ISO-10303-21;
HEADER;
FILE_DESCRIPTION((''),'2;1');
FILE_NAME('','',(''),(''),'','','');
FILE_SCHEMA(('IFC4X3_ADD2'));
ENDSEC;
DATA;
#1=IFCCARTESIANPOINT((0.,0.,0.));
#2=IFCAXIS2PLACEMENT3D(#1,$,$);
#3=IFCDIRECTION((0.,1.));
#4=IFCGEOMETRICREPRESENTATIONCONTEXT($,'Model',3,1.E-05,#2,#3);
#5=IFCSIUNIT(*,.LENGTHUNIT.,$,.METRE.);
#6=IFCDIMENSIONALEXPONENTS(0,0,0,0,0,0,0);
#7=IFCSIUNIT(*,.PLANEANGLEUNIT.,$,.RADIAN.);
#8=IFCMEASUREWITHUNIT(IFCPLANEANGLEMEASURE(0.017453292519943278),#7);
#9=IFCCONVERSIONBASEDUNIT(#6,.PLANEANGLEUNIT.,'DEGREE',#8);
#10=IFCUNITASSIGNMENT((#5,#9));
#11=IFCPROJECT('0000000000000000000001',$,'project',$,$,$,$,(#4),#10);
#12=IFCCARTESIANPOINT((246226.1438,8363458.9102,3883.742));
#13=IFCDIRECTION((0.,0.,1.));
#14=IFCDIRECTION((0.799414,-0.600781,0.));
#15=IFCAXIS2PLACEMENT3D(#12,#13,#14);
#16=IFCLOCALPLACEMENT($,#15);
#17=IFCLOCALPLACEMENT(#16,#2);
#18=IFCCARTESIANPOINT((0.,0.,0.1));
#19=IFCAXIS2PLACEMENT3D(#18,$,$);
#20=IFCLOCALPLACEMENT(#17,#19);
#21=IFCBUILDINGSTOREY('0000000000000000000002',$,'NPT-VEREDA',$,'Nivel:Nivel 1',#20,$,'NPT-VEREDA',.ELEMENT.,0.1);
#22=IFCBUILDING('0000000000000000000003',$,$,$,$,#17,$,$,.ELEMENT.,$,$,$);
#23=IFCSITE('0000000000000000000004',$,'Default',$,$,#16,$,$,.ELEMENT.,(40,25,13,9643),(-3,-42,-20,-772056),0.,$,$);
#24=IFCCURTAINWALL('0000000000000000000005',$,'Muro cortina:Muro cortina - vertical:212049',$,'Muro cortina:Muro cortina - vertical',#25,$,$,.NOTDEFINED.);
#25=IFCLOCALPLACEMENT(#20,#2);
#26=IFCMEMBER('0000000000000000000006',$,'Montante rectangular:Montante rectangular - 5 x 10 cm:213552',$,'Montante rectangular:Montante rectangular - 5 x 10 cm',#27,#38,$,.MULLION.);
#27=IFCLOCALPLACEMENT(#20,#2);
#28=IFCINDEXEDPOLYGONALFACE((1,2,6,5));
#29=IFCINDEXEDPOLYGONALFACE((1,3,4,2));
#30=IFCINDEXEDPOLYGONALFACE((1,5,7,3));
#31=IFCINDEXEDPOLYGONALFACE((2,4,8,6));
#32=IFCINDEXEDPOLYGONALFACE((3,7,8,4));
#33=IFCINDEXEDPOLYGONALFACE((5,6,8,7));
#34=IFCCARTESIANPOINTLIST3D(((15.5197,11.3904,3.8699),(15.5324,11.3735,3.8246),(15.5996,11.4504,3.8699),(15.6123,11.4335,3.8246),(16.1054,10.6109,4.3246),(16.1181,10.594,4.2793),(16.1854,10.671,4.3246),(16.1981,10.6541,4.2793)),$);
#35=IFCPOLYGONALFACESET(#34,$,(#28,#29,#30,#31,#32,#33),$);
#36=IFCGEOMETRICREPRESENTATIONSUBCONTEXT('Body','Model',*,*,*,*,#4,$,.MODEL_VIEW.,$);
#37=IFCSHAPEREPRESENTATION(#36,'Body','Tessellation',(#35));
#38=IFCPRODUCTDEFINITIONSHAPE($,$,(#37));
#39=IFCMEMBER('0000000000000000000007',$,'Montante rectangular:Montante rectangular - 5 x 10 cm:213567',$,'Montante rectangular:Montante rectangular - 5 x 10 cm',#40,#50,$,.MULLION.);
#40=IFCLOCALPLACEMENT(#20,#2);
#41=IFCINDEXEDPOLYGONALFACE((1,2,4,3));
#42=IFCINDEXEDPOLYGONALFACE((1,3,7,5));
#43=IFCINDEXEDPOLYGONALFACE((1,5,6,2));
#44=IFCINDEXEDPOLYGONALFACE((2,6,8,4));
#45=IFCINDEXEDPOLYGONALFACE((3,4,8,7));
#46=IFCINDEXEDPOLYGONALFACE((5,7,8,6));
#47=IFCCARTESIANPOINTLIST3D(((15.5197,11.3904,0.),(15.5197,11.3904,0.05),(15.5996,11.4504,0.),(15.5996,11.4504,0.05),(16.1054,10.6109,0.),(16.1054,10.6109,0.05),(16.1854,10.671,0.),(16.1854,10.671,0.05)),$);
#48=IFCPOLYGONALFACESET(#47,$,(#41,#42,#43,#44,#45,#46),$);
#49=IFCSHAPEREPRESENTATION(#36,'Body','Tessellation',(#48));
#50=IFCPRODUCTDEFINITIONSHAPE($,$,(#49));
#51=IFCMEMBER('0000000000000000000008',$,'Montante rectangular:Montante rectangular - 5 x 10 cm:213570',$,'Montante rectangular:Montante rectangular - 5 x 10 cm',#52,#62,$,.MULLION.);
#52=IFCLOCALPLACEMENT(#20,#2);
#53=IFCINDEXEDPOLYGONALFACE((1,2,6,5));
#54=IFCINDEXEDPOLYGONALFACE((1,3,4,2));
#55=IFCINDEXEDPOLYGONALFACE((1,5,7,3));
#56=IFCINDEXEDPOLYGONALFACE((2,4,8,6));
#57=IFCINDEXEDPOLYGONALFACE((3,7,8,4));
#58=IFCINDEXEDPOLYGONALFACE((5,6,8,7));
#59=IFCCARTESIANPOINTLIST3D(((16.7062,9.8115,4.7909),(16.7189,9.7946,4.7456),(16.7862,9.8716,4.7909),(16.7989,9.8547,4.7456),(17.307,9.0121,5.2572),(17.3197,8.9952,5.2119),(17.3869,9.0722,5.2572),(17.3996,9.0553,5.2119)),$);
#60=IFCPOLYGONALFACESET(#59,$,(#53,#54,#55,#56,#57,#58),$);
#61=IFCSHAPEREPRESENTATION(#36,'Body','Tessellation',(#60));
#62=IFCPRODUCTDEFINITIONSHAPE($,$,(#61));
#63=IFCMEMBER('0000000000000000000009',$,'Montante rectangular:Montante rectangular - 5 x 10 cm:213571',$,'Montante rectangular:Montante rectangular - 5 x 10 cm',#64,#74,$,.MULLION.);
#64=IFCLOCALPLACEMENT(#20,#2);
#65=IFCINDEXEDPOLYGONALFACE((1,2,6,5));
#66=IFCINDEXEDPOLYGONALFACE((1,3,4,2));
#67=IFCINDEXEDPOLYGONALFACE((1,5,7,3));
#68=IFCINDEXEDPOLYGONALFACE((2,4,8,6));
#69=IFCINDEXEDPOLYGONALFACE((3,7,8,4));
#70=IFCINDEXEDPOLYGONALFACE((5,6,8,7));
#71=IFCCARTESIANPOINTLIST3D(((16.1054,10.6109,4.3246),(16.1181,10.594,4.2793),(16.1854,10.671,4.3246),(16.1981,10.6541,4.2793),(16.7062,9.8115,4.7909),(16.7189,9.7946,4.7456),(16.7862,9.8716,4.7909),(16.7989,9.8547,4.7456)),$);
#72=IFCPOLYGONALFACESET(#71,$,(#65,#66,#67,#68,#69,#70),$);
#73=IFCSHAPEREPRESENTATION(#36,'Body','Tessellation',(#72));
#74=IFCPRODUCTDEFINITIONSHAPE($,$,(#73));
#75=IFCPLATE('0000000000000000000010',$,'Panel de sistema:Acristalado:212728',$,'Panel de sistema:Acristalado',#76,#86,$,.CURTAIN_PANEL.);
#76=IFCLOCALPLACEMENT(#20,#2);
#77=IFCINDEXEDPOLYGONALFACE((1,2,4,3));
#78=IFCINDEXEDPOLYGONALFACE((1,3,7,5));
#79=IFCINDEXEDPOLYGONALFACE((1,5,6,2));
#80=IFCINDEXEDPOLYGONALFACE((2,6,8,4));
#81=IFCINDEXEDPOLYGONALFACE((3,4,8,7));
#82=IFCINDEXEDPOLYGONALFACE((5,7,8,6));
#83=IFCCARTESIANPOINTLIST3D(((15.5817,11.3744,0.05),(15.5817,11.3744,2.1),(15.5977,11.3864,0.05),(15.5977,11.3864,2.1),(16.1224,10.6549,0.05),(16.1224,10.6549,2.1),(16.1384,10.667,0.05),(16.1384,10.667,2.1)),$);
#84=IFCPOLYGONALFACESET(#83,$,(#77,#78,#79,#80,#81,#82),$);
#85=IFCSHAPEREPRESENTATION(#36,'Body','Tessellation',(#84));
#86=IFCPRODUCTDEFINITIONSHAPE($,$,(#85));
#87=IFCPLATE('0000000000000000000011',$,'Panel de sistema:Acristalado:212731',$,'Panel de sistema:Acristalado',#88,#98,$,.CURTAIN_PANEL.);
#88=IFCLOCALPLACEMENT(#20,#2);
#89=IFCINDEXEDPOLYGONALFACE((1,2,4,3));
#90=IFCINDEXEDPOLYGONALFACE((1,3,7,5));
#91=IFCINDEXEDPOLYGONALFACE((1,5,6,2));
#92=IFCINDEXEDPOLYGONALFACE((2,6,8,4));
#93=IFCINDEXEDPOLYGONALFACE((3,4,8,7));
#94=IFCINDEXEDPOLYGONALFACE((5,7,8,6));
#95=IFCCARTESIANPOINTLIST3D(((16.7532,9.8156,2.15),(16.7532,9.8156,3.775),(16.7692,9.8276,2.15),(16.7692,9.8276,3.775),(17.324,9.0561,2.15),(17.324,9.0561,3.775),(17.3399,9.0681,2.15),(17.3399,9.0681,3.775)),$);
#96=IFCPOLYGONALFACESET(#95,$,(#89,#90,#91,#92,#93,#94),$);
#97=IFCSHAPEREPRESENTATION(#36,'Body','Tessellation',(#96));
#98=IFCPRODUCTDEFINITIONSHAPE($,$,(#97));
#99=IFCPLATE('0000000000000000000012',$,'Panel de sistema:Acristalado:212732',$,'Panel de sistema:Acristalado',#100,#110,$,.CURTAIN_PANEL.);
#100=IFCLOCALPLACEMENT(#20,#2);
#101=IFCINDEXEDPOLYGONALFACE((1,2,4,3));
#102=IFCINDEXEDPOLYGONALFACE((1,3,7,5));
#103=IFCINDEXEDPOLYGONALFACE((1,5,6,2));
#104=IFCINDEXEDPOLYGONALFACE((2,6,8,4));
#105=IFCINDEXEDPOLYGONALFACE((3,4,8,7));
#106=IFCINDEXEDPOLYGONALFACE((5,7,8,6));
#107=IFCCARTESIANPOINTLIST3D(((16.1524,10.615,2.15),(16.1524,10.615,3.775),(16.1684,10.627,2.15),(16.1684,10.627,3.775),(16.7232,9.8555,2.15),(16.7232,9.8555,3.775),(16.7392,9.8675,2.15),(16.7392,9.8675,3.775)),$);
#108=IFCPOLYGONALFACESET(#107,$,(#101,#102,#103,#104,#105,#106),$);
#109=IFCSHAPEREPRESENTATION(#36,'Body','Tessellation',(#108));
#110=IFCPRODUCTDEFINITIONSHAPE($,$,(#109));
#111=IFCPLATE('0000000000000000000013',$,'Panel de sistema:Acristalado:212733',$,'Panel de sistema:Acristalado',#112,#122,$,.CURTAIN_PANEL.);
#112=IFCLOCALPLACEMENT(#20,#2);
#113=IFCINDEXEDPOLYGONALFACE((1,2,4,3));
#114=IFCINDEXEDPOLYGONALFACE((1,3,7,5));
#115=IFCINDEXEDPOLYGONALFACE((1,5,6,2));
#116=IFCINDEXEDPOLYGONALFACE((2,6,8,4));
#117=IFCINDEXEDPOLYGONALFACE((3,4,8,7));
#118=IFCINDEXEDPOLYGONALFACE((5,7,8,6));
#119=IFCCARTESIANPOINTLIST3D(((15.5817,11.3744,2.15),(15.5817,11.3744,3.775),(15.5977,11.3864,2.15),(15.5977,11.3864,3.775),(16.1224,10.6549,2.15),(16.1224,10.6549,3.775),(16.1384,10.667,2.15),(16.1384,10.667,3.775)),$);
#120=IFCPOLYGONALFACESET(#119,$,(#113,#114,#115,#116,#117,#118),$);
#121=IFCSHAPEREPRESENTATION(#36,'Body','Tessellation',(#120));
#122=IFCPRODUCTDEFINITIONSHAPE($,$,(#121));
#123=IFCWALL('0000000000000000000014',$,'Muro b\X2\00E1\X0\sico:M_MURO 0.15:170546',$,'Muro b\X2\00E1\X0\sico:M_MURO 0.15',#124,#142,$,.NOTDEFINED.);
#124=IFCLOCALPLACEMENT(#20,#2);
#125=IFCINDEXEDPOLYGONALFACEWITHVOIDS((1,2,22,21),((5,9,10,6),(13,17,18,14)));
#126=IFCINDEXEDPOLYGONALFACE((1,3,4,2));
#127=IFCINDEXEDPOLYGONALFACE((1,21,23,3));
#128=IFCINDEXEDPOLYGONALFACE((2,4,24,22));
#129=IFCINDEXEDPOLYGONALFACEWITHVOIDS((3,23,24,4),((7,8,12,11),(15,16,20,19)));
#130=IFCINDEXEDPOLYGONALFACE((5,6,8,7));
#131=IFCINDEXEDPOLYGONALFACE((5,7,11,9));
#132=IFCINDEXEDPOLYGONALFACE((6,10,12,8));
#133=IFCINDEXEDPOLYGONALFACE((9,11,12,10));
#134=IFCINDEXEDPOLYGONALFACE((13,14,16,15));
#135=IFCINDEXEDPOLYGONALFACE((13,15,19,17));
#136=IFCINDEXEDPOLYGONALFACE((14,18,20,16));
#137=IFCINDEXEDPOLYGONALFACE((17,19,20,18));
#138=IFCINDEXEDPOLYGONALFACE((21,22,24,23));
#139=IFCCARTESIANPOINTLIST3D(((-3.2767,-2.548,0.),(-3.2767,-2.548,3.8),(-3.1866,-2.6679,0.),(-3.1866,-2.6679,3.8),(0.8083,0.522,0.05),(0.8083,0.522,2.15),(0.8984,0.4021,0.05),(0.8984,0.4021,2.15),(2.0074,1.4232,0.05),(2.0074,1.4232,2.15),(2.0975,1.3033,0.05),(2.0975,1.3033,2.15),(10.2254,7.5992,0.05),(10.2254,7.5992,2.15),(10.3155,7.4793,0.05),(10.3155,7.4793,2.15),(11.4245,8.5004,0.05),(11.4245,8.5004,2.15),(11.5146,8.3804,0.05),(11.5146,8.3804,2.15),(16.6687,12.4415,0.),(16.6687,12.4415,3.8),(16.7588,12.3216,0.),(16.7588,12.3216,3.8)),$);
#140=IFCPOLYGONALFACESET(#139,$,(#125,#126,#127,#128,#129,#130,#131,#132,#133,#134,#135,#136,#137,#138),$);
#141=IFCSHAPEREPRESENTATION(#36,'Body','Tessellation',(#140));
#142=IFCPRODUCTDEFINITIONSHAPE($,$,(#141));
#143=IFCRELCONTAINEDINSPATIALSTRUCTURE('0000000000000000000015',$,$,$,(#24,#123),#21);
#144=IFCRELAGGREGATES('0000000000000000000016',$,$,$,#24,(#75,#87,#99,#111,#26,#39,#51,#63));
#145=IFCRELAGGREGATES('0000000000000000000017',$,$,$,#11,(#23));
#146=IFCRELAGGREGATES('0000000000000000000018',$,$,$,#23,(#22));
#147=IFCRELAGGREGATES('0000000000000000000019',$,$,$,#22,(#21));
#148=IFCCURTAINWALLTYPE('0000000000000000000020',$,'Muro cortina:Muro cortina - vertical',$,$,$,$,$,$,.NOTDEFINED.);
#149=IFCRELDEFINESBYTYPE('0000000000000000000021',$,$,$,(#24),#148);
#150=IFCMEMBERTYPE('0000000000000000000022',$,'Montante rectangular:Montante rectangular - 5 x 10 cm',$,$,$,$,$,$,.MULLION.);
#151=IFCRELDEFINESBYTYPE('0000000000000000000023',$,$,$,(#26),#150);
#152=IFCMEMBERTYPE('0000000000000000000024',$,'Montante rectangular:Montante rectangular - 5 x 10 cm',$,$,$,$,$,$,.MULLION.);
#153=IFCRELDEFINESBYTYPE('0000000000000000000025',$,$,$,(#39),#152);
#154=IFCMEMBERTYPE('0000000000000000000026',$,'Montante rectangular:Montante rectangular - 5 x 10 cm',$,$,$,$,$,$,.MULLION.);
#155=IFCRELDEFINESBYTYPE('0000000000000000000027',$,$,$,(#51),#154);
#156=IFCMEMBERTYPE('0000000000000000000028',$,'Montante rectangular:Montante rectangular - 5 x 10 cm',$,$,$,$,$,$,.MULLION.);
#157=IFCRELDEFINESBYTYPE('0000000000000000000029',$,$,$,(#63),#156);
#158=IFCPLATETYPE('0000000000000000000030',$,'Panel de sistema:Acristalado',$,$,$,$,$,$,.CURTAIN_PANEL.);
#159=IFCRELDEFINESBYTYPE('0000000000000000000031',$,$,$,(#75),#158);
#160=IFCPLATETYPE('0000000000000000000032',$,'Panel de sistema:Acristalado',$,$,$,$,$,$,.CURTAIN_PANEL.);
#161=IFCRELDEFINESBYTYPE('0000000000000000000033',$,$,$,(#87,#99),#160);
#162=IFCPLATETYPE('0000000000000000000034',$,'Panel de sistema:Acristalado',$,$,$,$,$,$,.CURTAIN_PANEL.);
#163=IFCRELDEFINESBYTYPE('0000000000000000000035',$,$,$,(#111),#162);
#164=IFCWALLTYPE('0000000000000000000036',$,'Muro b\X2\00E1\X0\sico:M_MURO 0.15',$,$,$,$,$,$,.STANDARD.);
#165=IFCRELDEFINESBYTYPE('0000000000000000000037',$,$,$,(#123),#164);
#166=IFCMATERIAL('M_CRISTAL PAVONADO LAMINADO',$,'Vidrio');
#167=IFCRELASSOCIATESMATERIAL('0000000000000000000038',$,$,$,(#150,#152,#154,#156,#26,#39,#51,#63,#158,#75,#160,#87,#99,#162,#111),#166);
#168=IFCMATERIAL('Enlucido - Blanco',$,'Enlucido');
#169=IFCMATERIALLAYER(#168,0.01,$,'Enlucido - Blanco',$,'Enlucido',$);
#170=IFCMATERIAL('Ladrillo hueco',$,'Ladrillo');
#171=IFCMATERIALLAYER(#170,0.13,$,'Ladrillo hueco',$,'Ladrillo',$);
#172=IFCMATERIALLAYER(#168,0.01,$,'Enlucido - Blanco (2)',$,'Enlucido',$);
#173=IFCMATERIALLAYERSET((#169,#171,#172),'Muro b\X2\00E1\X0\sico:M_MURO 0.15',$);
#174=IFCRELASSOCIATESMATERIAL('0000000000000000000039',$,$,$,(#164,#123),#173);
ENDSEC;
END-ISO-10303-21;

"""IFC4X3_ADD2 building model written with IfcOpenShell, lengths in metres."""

from ifc_helpers import new_model, entity, si_unit, converted_unit, direction, frame, frame_2d, origin, origin_2d_with_axis, place, context, subcontext, project, spatial, polyline, rectangle, outline, extrude, source, transform, mapped, material, layer, layer_set, material_profile, profile_set, profile_usage, type_object, type_shapes, element, aggregate, save


model = new_model("IFC4X3_ADD2")

# Units and contexts
model_context = context("Model", 3, precision=1e-05, world=origin(), true_north=direction((0.0, 1.0)))
body_context = subcontext(model_context, "Body", "Model", "MODEL_VIEW")
ifc_project = project(units=[si_unit("LENGTHUNIT", "METRE"), converted_unit("PLANEANGLEUNIT", "DEGREE", entity("IfcPlaneAngleMeasure", 0.017453292519943278), si_unit("PLANEANGLEUNIT", "RADIAN"), dimensions=[0, 0, 0, 0, 0, 0, 0])], contexts=[model_context])

# Site, building, storey
site_placement = place(None, frame((246226.1438, 8363458.9102, 3883.742), z_axis=(0.0, 0.0, 1.0), x_axis=(0.799414, -0.600781, 0.0)))
site = spatial("IfcSite", under=ifc_project, at=site_placement, Name="Default", CompositionType="ELEMENT", RefLatitude=(40, 25, 13, 9643), RefLongitude=(-3, -42, -20, -772056), RefElevation=0.0)
building_placement = place(site_placement, origin())
building = spatial("IfcBuilding", under=site, at=building_placement, CompositionType="ELEMENT")
storey_placement = place(building_placement, frame((0.0, 0.0, 0.1)))
storey = spatial("IfcBuildingStorey", under=building, at=storey_placement, Name="NPT-VEREDA", ObjectType="Nivel:Nivel 1", LongName="NPT-VEREDA", CompositionType="ELEMENT", Elevation=0.1)

# Curtain wall, members, plates
curtain_wall_type = type_object("IfcCurtainWallType", Name="Muro cortina:Muro cortina - vertical", PredefinedType="NOTDEFINED")
curtain_wall_placement = place(storey_placement, frame((0.0, 0.0, -0.1)))
curtain_wall = element("IfcCurtainWall", 1, at=curtain_wall_placement, inside=storey, type_object=curtain_wall_type, Name="Muro cortina:Muro cortina - vertical:212049", ObjectType="Muro cortina:Muro cortina - vertical", PredefinedType="NOTDEFINED")
ifc_material_1 = material(Name="M_CRISTAL PAVONADO LAMINADO", Category="Vidrio")
ifc_material_profile = material_profile(ifc_material_1, outline(polyline([(-0.9872, -0.025), (0.948, -0.025), (0.948, 0.025), (-0.9087, 0.025), (-0.9872, -0.025)])), Name="Montante rectangular - 5 x 10 cm")
ifc_profile_set = profile_set([ifc_material_profile], Name="Montante rectangular - 5 x 10 cm")
ifc_profile_usage = profile_usage(ifc_profile_set)
member_type_1 = type_object("IfcMemberType", Name="Montante rectangular:Montante rectangular - 5 x 10 cm", PredefinedType="MULLION", material=ifc_profile_set)
shared_shape_1 = source(origin(), body_context, "Body", "SweptSolid", [
    extrude(rectangle(XDim=1.0758, YDim=0.1, at=frame_2d((0.0, 0.0), x_axis=(1.0, 0.0))), frame((-0.05, 0.0, -0.5379), z_axis=(1.0, 0.0, 0.0), x_axis=(0.0, 0.0, -1.0)), (0.0, 0.0, 1.0), 0.05),
])
type_shapes(member_type_1, [shared_shape_1])
member_1_placement = place(curtain_wall_placement, frame((15.5596, 11.4204, 3.9699), z_axis=(-0.544492, 0.724516, -0.422618), x_axis=(-0.253901, 0.337847, 0.906308)))
member_1 = element("IfcMember", 2, at=member_1_placement, type_object=member_type_1, material=ifc_profile_usage, Name="Montante rectangular:Montante rectangular - 5 x 10 cm:213552", ObjectType="Montante rectangular:Montante rectangular - 5 x 10 cm", PredefinedType="MULLION", context=body_context, shape_type="MappedRepresentation", body=[
    mapped(shared_shape_1, transform((0.0, 0.0, 0.0), scale=1.0)),
])
member_type_2 = type_object("IfcMemberType", Name="Montante rectangular:Montante rectangular - 5 x 10 cm", PredefinedType="MULLION", material=ifc_profile_set)
shared_shape_2 = source(origin(), body_context, "Body", "SweptSolid", [
    extrude(rectangle(XDim=0.05, YDim=0.1, at=frame_2d((0.0, 0.0), x_axis=(1.0, 0.0))), frame((-0.025, 0.0, -0.975)), (0.0, 0.0, 1.0), 0.975),
])
type_shapes(member_type_2, [shared_shape_2])
member_2_placement = place(curtain_wall_placement, frame((16.1454, 10.641, 0.1), z_axis=(0.60078, -0.799414, 0.0), x_axis=(0.0, 0.0, -1.0)))
member_2 = element("IfcMember", 3, at=member_2_placement, type_object=member_type_2, material=ifc_profile_usage, Name="Montante rectangular:Montante rectangular - 5 x 10 cm:213567", ObjectType="Montante rectangular:Montante rectangular - 5 x 10 cm", PredefinedType="MULLION", context=body_context, shape_type="MappedRepresentation", body=[
    mapped(shared_shape_2, transform((0.0, 0.0, 0.0), scale=1.0)),
])
member_type_3 = type_object("IfcMemberType", Name="Montante rectangular:Montante rectangular - 5 x 10 cm", PredefinedType="MULLION", material=ifc_profile_set)
shared_shape_3 = source(origin(), body_context, "Body", "SweptSolid", [
    extrude(rectangle(XDim=0.1, YDim=0.05, at=origin_2d_with_axis()), frame((-0.025, 0.0, -1.1034), z_axis=(0.0, 0.0, 1.0), x_axis=(0.0, 1.0, 0.0)), (0.0, 0.0, 1.0), 1.1034),
])
type_shapes(member_type_3, [shared_shape_3])
member_3_placement = place(curtain_wall_placement, frame((16.7462, 9.8415, 4.8909), z_axis=(-0.544492, 0.724516, -0.422618), x_axis=(-0.253901, 0.337847, 0.906308)))
member_3 = element("IfcMember", 4, at=member_3_placement, type_object=member_type_3, material=ifc_profile_usage, Name="Montante rectangular:Montante rectangular - 5 x 10 cm:213570", ObjectType="Montante rectangular:Montante rectangular - 5 x 10 cm", PredefinedType="MULLION", context=body_context, shape_type="MappedRepresentation", body=[
    mapped(shared_shape_3, transform((0.0, 0.0, 0.0), scale=1.0)),
])
member_type_4 = type_object("IfcMemberType", Name="Montante rectangular:Montante rectangular - 5 x 10 cm", PredefinedType="MULLION", material=ifc_profile_set)
shared_shape_4 = source(origin(), body_context, "Body", "SweptSolid", [
    extrude(rectangle(XDim=0.1, YDim=0.05, at=origin_2d_with_axis()), frame((-0.025, 0.0, -1.1034), z_axis=(0.0, 0.0, 1.0), x_axis=(0.0, 1.0, 0.0)), (0.0, 0.0, 1.0), 1.1034),
])
type_shapes(member_type_4, [shared_shape_4])
member_4_placement = place(curtain_wall_placement, frame((16.1454, 10.641, 4.4246), z_axis=(-0.544492, 0.724516, -0.422618), x_axis=(-0.253901, 0.337847, 0.906308)))
member_4 = element("IfcMember", 5, at=member_4_placement, type_object=member_type_4, material=ifc_profile_usage, Name="Montante rectangular:Montante rectangular - 5 x 10 cm:213571", ObjectType="Montante rectangular:Montante rectangular - 5 x 10 cm", PredefinedType="MULLION", context=body_context, shape_type="MappedRepresentation", body=[
    mapped(shared_shape_4, transform((0.0, 0.0, 0.0), scale=1.0)),
])
plate_type_1 = type_object("IfcPlateType", Name="Panel de sistema:Acristalado", PredefinedType="CURTAIN_PANEL", material=ifc_material_1)
shared_shape_5 = source(origin(), body_context, "Body", "SweptSolid", [
    extrude(rectangle(XDim=0.02, YDim=0.9, at=frame_2d((0.0, 0.0), x_axis=(1.0, 0.0))), frame((0.0, 0.0, 0.0), z_axis=(0.0, 0.0, 1.0), x_axis=(0.0, 1.0, 0.0)), (0.0, 0.0, 1.0), 2.05),
])
type_shapes(plate_type_1, [shared_shape_5])
plate_1_placement = place(curtain_wall_placement, frame((15.86, 11.0207, 0.15), z_axis=(0.0, 0.0, 1.0), x_axis=(-0.60078, 0.799414, 0.0)))
plate_1 = element("IfcPlate", 6, at=plate_1_placement, type_object=plate_type_1, material=ifc_material_1, Name="Panel de sistema:Acristalado:212728", ObjectType="Panel de sistema:Acristalado", PredefinedType="CURTAIN_PANEL", context=body_context, shape_type="MappedRepresentation", body=[
    mapped(shared_shape_5, transform((0.0, 0.0, 0.0), scale=1.0)),
])
plate_type_2 = type_object("IfcPlateType", Name="Panel de sistema:Acristalado", PredefinedType="CURTAIN_PANEL", material=ifc_material_1)
shared_shape_6 = source(origin(), body_context, "Body", "SweptSolid", [
    extrude(rectangle(XDim=0.02, YDim=0.95, at=frame_2d((0.0, 0.0), x_axis=(1.0, 0.0))), frame((0.0, 0.0, 0.0), z_axis=(0.0, 0.0, 1.0), x_axis=(0.0, 1.0, 0.0)), (0.0, 0.0, 1.0), 1.625),
])
type_shapes(plate_type_2, [shared_shape_6])
plate_2_placement = place(curtain_wall_placement, frame((17.0466, 9.4418, 2.25), z_axis=(0.0, 0.0, 1.0), x_axis=(-0.60078, 0.799414, 0.0)))
plate_2 = element("IfcPlate", 7, at=plate_2_placement, type_object=plate_type_2, material=ifc_material_1, Name="Panel de sistema:Acristalado:212731", ObjectType="Panel de sistema:Acristalado", PredefinedType="CURTAIN_PANEL", context=body_context, shape_type="MappedRepresentation", body=[
    mapped(shared_shape_6, transform((0.0, 0.0, 0.0), scale=1.0)),
])
plate_3_placement = place(curtain_wall_placement, frame((16.4458, 10.2413, 2.25), z_axis=(0.0, 0.0, 1.0), x_axis=(-0.60078, 0.799414, 0.0)))
plate_3 = element("IfcPlate", 8, at=plate_3_placement, type_object=plate_type_2, material=ifc_material_1, Name="Panel de sistema:Acristalado:212732", ObjectType="Panel de sistema:Acristalado", PredefinedType="CURTAIN_PANEL", context=body_context, shape_type="MappedRepresentation", body=[
    mapped(shared_shape_6, transform((0.0, 0.0, 0.0), scale=1.0)),
])
plate_type_3 = type_object("IfcPlateType", Name="Panel de sistema:Acristalado", PredefinedType="CURTAIN_PANEL", material=ifc_material_1)
shared_shape_7 = source(origin(), body_context, "Body", "SweptSolid", [
    extrude(rectangle(XDim=0.02, YDim=0.9, at=frame_2d((0.0, 0.0), x_axis=(1.0, 0.0))), frame((0.0, 0.0, 0.0), z_axis=(0.0, 0.0, 1.0), x_axis=(0.0, 1.0, 0.0)), (0.0, 0.0, 1.0), 1.625),
])
type_shapes(plate_type_3, [shared_shape_7])
plate_4_placement = place(curtain_wall_placement, frame((15.86, 11.0207, 2.25), z_axis=(0.0, 0.0, 1.0), x_axis=(-0.60078, 0.799414, 0.0)))
plate_4 = element("IfcPlate", 9, at=plate_4_placement, type_object=plate_type_3, material=ifc_material_1, Name="Panel de sistema:Acristalado:212733", ObjectType="Panel de sistema:Acristalado", PredefinedType="CURTAIN_PANEL", context=body_context, shape_type="MappedRepresentation", body=[
    mapped(shared_shape_7, transform((0.0, 0.0, 0.0), scale=1.0)),
])
aggregate(curtain_wall, [plate_1, plate_2, plate_3, plate_4, member_1, member_2, member_3, member_4])

# Wall, openings
ifc_material_2 = material(Name="Enlucido - Blanco", Category="Enlucido")
ifc_layer_1 = layer(ifc_material_2, 0.01, Name="Enlucido - Blanco", Category="Enlucido")
ifc_material_3 = material(Name="Ladrillo hueco", Category="Ladrillo")
ifc_layer_2 = layer(ifc_material_3, 0.13, Name="Ladrillo hueco", Category="Ladrillo")
ifc_layer_3 = layer(ifc_material_2, 0.01, Name="Enlucido - Blanco (2)", Category="Enlucido")
ifc_layer_set = layer_set([ifc_layer_1, ifc_layer_2, ifc_layer_3], Name="Muro básico:M_MURO 0.15")
wall_type = type_object("IfcWallType", Name="Muro básico:M_MURO 0.15", PredefinedType="STANDARD", material=ifc_layer_set)
wall_placement = place(storey_placement, frame((16.7137, 12.3815, 0.0), z_axis=(0.0, 0.0, 1.0), x_axis=(-0.799414, -0.60078, 0.0)))
wall = element("IfcWall", 10, at=wall_placement, inside=storey, type_object=wall_type, material=ifc_layer_set, Name="Muro básico:M_MURO 0.15:170546", ObjectType="Muro básico:M_MURO 0.15", PredefinedType="NOTDEFINED", context=body_context, shape_type="SweptSolid", body=[
    extrude(rectangle(XDim=24.95, YDim=0.15, at=frame_2d((12.475, 0.0), x_axis=(-1.0, 0.0))), origin(), (0.0, 0.0, 1.0), 3.8),
])
opening_1_placement = place(wall_placement, frame((18.34, -0.075, 0.05)))
element("IfcOpeningElement", 11, at=opening_1_placement, cuts=wall, PredefinedType="OPENING", context=body_context, shape_type="SweptSolid", body=[
    extrude(rectangle(XDim=2.1, YDim=1.5, at=frame_2d((1.05, 0.75), x_axis=(1.0, 0.0))), frame((0.0, 0.0, 0.0), z_axis=(0.0, 1.0, 0.0), x_axis=(0.0, 0.0, 1.0)), (0.0, 0.0, 1.0), 0.15),
])
opening_2_placement = place(wall_placement, frame((6.56, -0.075, 0.05)))
element("IfcOpeningElement", 12, at=opening_2_placement, cuts=wall, PredefinedType="OPENING", context=body_context, shape_type="SweptSolid", body=[
    extrude(rectangle(XDim=2.1, YDim=1.5, at=frame_2d((1.05, 0.75), x_axis=(1.0, 0.0))), frame((0.0, 0.0, 0.0), z_axis=(0.0, 1.0, 0.0), x_axis=(0.0, 0.0, 1.0)), (0.0, 0.0, 1.0), 0.15),
])

save(model, "model.ifc")
